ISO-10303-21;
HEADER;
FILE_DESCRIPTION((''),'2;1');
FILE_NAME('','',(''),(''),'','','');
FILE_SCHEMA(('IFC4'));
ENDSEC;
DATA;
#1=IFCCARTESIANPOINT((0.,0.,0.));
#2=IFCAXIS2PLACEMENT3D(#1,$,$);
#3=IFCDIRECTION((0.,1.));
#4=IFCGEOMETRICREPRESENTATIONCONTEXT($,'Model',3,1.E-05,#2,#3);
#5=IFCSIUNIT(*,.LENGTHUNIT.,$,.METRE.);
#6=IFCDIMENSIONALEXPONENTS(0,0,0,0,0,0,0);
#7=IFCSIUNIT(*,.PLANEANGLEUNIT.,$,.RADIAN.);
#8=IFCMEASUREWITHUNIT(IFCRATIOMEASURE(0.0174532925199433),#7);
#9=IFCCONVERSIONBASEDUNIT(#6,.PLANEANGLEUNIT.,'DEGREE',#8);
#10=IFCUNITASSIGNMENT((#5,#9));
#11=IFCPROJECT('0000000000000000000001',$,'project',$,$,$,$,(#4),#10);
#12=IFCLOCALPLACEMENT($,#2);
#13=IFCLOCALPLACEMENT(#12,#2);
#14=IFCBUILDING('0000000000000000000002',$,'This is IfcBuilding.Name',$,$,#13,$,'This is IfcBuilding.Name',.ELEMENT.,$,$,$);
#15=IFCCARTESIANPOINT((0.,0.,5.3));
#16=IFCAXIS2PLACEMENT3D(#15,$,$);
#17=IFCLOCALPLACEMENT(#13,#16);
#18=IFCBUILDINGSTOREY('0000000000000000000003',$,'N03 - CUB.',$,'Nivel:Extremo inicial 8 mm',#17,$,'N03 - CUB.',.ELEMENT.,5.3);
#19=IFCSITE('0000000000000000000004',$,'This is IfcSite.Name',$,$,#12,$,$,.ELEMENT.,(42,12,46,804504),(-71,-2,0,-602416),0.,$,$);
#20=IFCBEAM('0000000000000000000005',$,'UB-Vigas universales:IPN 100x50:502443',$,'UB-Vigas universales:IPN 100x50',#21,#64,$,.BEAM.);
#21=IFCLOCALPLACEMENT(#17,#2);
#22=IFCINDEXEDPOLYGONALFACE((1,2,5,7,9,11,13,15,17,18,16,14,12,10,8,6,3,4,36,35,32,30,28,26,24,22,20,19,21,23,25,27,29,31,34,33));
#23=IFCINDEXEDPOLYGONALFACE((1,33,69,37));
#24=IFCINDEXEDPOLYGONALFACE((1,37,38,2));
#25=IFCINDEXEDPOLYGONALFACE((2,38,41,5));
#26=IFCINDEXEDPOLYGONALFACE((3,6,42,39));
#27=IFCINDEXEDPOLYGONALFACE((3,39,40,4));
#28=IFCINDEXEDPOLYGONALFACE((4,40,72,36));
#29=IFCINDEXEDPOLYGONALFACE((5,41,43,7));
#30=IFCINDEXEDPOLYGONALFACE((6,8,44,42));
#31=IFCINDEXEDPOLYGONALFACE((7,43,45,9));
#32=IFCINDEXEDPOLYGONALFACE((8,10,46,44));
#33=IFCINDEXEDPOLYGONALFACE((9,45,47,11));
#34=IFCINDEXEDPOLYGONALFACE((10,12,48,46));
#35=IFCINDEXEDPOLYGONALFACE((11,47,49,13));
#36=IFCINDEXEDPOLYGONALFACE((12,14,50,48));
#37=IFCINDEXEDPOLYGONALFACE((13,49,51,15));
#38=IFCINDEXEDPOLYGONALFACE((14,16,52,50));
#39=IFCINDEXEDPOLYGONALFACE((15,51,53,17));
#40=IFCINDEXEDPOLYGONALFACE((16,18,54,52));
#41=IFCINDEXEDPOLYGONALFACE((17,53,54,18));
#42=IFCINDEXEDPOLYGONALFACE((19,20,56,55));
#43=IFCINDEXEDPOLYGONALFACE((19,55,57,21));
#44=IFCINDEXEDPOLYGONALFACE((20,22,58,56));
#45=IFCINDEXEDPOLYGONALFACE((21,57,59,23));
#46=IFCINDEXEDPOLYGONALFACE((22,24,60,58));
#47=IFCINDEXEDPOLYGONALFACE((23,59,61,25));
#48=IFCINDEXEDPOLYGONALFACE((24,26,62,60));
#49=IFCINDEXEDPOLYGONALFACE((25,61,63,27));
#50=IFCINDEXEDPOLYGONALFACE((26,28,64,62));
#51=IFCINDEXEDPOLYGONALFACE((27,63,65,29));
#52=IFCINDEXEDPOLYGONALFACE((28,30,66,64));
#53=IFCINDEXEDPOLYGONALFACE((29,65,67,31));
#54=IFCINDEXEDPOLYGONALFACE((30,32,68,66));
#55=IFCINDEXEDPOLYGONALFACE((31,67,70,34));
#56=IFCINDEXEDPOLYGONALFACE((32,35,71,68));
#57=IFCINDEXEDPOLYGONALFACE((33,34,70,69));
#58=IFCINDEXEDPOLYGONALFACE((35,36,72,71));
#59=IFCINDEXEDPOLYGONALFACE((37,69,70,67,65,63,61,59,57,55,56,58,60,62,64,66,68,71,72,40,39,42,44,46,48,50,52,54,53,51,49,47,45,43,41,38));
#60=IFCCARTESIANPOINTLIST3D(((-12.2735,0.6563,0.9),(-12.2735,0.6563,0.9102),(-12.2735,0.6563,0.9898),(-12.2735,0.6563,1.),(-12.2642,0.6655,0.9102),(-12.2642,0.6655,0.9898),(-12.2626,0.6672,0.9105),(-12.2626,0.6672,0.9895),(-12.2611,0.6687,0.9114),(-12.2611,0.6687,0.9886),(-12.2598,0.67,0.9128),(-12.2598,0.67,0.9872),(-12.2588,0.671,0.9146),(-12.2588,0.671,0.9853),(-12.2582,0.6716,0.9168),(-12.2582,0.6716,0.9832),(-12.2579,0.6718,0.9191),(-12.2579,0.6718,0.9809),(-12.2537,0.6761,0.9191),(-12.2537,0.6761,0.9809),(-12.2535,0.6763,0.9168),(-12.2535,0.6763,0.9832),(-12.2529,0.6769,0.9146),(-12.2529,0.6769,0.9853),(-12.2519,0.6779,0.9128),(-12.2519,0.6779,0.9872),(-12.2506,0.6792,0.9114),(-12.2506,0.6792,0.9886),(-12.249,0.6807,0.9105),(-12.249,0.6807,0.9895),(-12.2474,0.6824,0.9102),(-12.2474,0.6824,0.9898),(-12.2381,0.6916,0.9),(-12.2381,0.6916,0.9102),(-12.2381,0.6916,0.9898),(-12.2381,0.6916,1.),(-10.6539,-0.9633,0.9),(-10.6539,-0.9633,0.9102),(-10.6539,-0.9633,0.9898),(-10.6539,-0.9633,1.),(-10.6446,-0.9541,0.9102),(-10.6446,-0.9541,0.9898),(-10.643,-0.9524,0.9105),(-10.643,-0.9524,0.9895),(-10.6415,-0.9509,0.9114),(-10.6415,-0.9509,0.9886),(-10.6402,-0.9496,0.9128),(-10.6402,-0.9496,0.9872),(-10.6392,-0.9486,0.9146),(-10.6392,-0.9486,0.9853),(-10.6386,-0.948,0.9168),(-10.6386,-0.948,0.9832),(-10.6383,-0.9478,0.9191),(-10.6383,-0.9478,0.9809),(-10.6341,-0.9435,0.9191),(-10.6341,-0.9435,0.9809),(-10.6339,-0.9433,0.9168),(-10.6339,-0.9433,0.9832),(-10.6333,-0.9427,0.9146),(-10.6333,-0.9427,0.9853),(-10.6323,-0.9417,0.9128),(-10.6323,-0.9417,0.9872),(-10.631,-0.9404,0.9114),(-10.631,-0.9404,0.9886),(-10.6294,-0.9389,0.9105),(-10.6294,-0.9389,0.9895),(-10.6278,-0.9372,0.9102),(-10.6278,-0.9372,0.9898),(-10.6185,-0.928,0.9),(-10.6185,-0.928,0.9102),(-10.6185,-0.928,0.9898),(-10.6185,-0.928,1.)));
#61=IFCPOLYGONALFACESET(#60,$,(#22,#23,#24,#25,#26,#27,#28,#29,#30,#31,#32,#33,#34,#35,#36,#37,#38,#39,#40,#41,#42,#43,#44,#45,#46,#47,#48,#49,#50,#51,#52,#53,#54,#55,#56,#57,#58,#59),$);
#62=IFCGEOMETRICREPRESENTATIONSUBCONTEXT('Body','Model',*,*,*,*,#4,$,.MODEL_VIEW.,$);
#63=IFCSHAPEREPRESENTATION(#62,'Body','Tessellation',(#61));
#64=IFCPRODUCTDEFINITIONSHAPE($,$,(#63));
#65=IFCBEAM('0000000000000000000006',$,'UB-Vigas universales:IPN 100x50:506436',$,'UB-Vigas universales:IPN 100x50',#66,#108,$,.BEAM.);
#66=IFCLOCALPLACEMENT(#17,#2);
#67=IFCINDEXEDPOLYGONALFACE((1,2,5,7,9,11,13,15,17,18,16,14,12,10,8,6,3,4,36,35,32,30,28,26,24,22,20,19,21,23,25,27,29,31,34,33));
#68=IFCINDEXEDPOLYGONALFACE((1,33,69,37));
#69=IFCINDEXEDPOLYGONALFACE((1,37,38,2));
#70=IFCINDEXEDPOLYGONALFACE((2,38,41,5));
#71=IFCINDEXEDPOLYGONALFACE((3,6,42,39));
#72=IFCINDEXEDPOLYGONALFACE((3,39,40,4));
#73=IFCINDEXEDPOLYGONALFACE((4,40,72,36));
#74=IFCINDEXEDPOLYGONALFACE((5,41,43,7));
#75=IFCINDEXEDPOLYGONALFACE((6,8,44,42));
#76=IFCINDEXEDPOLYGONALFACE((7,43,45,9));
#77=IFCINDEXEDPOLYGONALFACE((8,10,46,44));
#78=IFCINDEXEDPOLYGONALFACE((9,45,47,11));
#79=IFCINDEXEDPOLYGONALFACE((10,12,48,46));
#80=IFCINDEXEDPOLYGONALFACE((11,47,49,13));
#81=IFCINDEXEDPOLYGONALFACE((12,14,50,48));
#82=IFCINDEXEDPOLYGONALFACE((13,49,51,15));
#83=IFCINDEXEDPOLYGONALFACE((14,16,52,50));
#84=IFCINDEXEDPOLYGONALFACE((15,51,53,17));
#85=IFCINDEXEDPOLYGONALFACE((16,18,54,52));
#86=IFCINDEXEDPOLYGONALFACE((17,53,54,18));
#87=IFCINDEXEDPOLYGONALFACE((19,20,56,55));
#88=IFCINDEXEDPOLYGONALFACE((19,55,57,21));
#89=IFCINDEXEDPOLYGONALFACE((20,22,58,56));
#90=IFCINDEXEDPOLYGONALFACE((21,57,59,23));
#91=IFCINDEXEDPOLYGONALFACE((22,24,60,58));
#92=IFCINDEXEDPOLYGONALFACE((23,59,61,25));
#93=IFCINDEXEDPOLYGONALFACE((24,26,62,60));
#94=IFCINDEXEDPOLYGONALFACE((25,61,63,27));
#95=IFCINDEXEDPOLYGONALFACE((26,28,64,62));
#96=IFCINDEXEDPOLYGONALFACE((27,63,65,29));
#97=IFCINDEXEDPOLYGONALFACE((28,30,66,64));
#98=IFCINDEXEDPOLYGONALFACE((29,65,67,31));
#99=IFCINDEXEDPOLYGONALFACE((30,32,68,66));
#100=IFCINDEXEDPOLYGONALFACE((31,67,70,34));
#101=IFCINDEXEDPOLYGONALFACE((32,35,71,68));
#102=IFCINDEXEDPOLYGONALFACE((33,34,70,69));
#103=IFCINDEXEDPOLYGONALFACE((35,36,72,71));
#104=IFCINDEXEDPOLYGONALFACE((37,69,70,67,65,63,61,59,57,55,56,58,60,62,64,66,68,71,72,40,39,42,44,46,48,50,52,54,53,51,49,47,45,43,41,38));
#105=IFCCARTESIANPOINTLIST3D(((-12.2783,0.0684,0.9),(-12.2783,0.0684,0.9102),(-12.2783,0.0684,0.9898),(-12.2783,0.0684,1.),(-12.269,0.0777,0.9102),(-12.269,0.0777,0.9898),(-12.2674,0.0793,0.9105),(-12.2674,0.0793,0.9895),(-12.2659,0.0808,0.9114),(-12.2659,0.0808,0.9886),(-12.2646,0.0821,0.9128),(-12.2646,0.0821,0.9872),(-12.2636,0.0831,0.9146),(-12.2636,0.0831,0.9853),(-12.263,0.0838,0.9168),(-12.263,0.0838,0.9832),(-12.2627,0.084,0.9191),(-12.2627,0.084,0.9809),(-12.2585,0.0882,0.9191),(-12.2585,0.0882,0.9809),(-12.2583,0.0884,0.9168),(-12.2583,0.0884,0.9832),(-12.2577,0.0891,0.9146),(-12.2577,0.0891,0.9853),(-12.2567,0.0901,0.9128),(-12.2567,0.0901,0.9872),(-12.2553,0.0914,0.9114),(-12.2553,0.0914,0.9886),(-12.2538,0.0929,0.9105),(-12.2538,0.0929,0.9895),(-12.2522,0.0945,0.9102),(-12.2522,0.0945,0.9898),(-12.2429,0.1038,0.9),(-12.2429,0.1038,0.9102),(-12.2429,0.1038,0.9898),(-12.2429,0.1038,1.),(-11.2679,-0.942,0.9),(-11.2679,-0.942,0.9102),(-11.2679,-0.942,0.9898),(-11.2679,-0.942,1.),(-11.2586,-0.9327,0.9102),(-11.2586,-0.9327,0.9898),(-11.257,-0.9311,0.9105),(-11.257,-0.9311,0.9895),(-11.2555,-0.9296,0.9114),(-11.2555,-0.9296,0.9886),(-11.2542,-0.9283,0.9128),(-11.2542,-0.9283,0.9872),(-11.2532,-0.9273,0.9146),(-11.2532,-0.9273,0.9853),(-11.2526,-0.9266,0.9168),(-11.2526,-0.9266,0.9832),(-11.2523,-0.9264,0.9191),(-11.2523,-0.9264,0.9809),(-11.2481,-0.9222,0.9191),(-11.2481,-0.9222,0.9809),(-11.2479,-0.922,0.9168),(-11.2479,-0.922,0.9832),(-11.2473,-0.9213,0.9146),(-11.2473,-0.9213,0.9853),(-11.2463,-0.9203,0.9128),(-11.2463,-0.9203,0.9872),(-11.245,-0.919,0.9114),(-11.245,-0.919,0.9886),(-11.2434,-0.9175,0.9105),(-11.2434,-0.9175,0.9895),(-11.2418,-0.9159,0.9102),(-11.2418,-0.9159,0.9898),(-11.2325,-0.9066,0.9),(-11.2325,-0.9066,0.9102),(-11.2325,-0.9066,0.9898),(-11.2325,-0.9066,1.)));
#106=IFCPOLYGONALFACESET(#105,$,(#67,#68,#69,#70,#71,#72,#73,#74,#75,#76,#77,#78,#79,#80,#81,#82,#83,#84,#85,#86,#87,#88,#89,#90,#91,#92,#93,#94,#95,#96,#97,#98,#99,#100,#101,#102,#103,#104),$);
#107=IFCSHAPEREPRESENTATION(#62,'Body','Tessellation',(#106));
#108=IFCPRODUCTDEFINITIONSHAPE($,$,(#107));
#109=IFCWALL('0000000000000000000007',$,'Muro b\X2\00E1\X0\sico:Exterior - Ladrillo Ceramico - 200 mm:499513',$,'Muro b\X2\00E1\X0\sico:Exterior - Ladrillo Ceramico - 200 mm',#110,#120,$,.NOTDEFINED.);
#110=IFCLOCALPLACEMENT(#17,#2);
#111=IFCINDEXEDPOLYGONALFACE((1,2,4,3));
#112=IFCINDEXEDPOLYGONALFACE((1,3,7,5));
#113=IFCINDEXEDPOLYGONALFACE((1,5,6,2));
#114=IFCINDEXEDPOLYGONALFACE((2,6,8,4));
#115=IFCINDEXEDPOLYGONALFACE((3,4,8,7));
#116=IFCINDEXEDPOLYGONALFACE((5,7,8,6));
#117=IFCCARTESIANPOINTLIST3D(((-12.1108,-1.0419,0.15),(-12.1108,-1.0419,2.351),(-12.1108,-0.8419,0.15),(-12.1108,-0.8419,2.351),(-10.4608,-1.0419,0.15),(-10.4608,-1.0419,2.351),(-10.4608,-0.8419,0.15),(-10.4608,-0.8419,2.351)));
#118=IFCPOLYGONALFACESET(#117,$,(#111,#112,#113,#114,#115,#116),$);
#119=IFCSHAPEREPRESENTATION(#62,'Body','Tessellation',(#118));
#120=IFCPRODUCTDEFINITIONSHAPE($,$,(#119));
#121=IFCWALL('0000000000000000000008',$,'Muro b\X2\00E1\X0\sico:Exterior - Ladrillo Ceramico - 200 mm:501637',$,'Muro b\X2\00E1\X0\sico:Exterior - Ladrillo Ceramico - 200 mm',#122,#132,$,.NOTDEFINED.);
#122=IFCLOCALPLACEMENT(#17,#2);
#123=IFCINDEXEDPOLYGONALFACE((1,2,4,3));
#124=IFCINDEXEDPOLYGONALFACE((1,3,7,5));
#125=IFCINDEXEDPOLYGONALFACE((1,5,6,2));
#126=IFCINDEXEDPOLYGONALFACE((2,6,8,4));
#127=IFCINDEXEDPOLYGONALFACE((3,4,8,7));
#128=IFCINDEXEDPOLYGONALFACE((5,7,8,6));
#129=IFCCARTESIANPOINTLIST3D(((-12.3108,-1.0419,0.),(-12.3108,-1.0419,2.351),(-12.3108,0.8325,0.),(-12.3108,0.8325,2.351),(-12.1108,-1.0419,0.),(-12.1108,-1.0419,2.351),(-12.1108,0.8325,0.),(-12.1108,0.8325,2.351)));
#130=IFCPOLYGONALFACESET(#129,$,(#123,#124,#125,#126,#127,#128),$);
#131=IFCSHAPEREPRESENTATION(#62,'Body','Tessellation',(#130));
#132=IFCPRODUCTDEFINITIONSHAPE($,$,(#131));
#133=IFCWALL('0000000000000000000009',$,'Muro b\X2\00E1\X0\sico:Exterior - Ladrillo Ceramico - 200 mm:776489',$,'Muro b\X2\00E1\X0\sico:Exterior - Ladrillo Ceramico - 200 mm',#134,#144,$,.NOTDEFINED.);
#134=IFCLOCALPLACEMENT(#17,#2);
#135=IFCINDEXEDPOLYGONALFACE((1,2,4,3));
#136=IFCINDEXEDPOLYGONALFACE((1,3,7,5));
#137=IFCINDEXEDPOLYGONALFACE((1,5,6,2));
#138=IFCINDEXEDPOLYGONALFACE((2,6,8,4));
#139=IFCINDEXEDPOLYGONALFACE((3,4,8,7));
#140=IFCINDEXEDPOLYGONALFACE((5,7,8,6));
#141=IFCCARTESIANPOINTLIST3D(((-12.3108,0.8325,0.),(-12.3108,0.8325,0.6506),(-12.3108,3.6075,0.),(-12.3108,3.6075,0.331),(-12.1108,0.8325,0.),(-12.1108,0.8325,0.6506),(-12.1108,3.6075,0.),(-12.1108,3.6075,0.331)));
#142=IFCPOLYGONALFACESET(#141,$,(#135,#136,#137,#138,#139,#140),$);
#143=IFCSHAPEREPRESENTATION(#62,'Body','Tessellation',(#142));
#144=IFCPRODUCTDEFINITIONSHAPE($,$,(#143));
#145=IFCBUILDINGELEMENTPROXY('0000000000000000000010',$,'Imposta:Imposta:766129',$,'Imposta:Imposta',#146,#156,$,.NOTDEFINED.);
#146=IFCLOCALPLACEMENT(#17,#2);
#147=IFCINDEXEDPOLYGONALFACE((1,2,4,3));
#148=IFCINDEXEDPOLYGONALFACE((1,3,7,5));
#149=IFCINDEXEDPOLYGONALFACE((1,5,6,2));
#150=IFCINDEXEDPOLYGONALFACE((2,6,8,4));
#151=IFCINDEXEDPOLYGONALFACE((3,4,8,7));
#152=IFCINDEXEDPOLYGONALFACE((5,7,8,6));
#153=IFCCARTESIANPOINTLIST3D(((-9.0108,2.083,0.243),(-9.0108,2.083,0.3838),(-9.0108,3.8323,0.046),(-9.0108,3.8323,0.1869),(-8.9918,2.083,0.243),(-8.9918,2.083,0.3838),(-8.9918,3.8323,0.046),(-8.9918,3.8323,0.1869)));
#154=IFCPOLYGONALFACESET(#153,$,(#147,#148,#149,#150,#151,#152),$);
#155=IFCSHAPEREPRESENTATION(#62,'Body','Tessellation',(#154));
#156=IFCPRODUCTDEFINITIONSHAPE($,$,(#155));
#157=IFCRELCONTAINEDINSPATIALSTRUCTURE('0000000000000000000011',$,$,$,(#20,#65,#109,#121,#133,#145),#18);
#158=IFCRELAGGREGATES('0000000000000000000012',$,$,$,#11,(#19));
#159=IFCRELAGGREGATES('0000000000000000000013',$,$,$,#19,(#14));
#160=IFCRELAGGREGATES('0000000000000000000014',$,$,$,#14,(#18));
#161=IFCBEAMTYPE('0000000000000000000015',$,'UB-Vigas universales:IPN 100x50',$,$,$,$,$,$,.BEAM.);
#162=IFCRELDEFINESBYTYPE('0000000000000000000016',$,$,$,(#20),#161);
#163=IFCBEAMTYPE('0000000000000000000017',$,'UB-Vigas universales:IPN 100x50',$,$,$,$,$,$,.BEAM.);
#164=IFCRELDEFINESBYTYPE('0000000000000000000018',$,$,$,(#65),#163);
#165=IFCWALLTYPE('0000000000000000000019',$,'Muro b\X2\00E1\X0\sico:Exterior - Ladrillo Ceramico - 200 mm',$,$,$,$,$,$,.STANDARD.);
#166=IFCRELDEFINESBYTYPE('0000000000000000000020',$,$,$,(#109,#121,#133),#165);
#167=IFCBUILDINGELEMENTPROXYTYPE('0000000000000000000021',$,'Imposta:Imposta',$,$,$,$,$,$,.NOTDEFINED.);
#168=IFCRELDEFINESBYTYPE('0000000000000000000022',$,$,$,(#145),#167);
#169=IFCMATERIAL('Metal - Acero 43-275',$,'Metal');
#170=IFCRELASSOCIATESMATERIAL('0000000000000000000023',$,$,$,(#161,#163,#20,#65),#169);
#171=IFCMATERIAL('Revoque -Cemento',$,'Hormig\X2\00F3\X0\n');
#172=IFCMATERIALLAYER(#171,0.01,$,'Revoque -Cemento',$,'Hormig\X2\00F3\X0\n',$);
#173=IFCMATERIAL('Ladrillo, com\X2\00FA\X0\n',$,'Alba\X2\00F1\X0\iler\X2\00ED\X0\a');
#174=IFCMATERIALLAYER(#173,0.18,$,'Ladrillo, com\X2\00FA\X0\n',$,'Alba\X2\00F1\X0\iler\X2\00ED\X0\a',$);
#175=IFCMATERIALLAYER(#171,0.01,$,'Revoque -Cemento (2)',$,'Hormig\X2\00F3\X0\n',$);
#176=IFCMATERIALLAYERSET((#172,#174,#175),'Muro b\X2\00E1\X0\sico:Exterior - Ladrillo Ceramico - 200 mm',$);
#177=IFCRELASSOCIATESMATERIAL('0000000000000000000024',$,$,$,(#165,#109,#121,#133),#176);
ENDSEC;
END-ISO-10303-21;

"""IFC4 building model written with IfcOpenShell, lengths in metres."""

from ifc_helpers import new_model, entity, si_unit, converted_unit, direction, frame, frame_2d, origin, place, context, subcontext, project, spatial, polyline, rectangle, i_section, outline, extrude, clip, halfspace, source, transform, mapped, material, layer, layer_set, layer_usage, material_profile, profile_set, profile_usage, type_object, type_shapes, element, save


model = new_model("IFC4")

# Units and contexts
model_context = context("Model", 3, precision=1e-05, world=origin(), true_north=direction((0.0, 1.0)))
body_context = subcontext(model_context, "Body", "Model", "MODEL_VIEW")
ifc_project = project(units=[si_unit("LENGTHUNIT", "METRE"), converted_unit("PLANEANGLEUNIT", "DEGREE", entity("IfcRatioMeasure", 0.0174532925199433), si_unit("PLANEANGLEUNIT", "RADIAN"), dimensions=[0, 0, 0, 0, 0, 0, 0])], contexts=[model_context])

# Site, building, storey
site_placement = place(None, origin())
site = spatial("IfcSite", under=ifc_project, at=site_placement, Name="This is IfcSite.Name", CompositionType="ELEMENT", RefLatitude=(42, 12, 46, 804504), RefLongitude=(-71, -2, 0, -602416), RefElevation=0.0)
building_placement = place(site_placement, origin())
building = spatial("IfcBuilding", under=site, at=building_placement, Name="This is IfcBuilding.Name", LongName="This is IfcBuilding.Name", CompositionType="ELEMENT")
storey_placement = place(building_placement, frame((0.0, 0.0, 5.3)))
storey = spatial("IfcBuildingStorey", under=building, at=storey_placement, Name="N03 - CUB.", ObjectType="Nivel:Extremo inicial 8 mm", LongName="N03 - CUB.", CompositionType="ELEMENT", Elevation=5.3)

# Beams
ifc_material_1 = material(Name="Metal - Acero 43-275", Category="Metal")
ifc_material_profile = material_profile(ifc_material_1, i_section(OverallWidth=0.05, OverallDepth=0.1, WebThickness=0.006, FlangeThickness=0.0102, FilletRadius=0.0089, at=frame_2d((0.0, 0.0), x_axis=(0.0, 1.0))), Name="IPN 100x50")
ifc_profile_set = profile_set([ifc_material_profile], Name="IPN 100x50")
ifc_profile_usage_1 = profile_usage(ifc_profile_set, cardinal=8)
beam_type_1 = type_object("IfcBeamType", Name="UB-Vigas universales:IPN 100x50", PredefinedType="BEAM", material=ifc_profile_set)
shared_shape_1 = source(origin(), body_context, "Body", "SweptSolid", [
    extrude(i_section(OverallWidth=0.05, OverallDepth=0.1, WebThickness=0.006, FlangeThickness=0.0102, FilletRadius=0.0089, at=frame_2d((0.0, 0.0), x_axis=(0.0, 1.0))), frame((-1.1226, 0.0, 0.0), z_axis=(1.0, 0.0, 0.0), x_axis=(0.0, 0.0, -1.0)), (0.0, 0.0, 1.0), 2.2905),
])
type_shapes(beam_type_1, [shared_shape_1])
beam_1_placement = place(storey_placement, frame((-11.43, -0.1518, 0.95), z_axis=(0.0, 0.0, 1.0), x_axis=(-0.707107, 0.707107, 0.0)))
element("IfcBeam", 1, at=beam_1_placement, inside=storey, type_object=beam_type_1, material=ifc_profile_usage_1, Name="UB-Vigas universales:IPN 100x50:502443", ObjectType="UB-Vigas universales:IPN 100x50", PredefinedType="BEAM", context=body_context, shape_type="MappedRepresentation", body=[
    mapped(shared_shape_1, transform((0.0, 0.0, 0.0), scale=1.0)),
])
ifc_profile_usage_2 = profile_usage(ifc_profile_set, cardinal=8)
beam_type_2 = type_object("IfcBeamType", Name="UB-Vigas universales:IPN 100x50", PredefinedType="BEAM", material=ifc_profile_set)
shared_shape_2 = source(origin(), body_context, "Body", "SweptSolid", [
    extrude(i_section(OverallWidth=0.05, OverallDepth=0.1, WebThickness=0.006, FlangeThickness=0.0102, FilletRadius=0.0089, at=frame_2d((0.0, 0.0), x_axis=(0.0, 1.0))), frame((-0.6611, 0.0, 0.0), z_axis=(1.0, 0.0, 0.0), x_axis=(0.0, 0.0, -1.0)), (0.0, 0.0, 1.0), 1.4289),
])
type_shapes(beam_type_2, [shared_shape_2])
beam_2_placement = place(storey_placement, frame((-11.7177, -0.4568, 0.95), z_axis=(0.0, 0.0, 1.0), x_axis=(-0.707107, 0.707107, 0.0)))
element("IfcBeam", 2, at=beam_2_placement, inside=storey, type_object=beam_type_2, material=ifc_profile_usage_2, Name="UB-Vigas universales:IPN 100x50:506436", ObjectType="UB-Vigas universales:IPN 100x50", PredefinedType="BEAM", context=body_context, shape_type="MappedRepresentation", body=[
    mapped(shared_shape_2, transform((0.0, 0.0, 0.0), scale=1.0)),
])

# Walls
ifc_material_2 = material(Name="Revoque -Cemento", Category="Hormigón")
ifc_layer_1 = layer(ifc_material_2, 0.01, Name="Revoque -Cemento", Category="Hormigón")
ifc_material_3 = material(Name="Ladrillo, común", Category="Albañilería")
ifc_layer_2 = layer(ifc_material_3, 0.18, Name="Ladrillo, común", Category="Albañilería")
ifc_layer_3 = layer(ifc_material_2, 0.01, Name="Revoque -Cemento (2)", Category="Hormigón")
ifc_layer_set_1 = layer_set([ifc_layer_1, ifc_layer_2, ifc_layer_3], Name="Muro básico:Exterior - Ladrillo Ceramico - 200 mm")
ifc_layer_usage_1 = layer_usage(ifc_layer_set_1, "AXIS2", "NEGATIVE", 0.1)
wall_type = type_object("IfcWallType", Name="Muro básico:Exterior - Ladrillo Ceramico - 200 mm", PredefinedType="STANDARD", material=ifc_layer_set_1)
wall_1_placement = place(storey_placement, frame((-10.4608, -0.9419, 0.15), z_axis=(0.0, 0.0, 1.0), x_axis=(-1.0, 0.0, 0.0)))
element("IfcWall", 3, at=wall_1_placement, inside=storey, type_object=wall_type, material=ifc_layer_usage_1, Name="Muro básico:Exterior - Ladrillo Ceramico - 200 mm:499513", ObjectType="Muro básico:Exterior - Ladrillo Ceramico - 200 mm", PredefinedType="NOTDEFINED", context=body_context, shape_type="SweptSolid", body=[
    extrude(rectangle(XDim=1.65, YDim=0.2, at=frame_2d((0.825, 0.0), x_axis=(-1.0, 0.0))), origin(), (0.0, 0.0, 1.0), 2.201),
])
ifc_layer_usage_2 = layer_usage(ifc_layer_set_1, "AXIS2", "POSITIVE", -0.1)
wall_2_placement = place(storey_placement, frame((-12.2108, 0.8325, 0.0), z_axis=(0.0, 0.0, 1.0), x_axis=(0.0, -1.0, 0.0)))
element("IfcWall", 4, at=wall_2_placement, inside=storey, type_object=wall_type, material=ifc_layer_usage_2, Name="Muro básico:Exterior - Ladrillo Ceramico - 200 mm:501637", ObjectType="Muro básico:Exterior - Ladrillo Ceramico - 200 mm", PredefinedType="NOTDEFINED", context=body_context, shape_type="SweptSolid", body=[
    extrude(rectangle(XDim=1.8744, YDim=0.2, at=frame_2d((0.9372, 0.0), x_axis=(-1.0, 0.0))), origin(), (0.0, 0.0, 1.0), 2.351),
])
ifc_layer_usage_3 = layer_usage(ifc_layer_set_1, "AXIS2", "POSITIVE", -0.1)
wall_3_placement = place(storey_placement, frame((-12.2108, 3.6075, 0.0), z_axis=(0.0, 0.0, 1.0), x_axis=(0.0, -1.0, 0.0)))
element("IfcWall", 5, at=wall_3_placement, inside=storey, type_object=wall_type, material=ifc_layer_usage_3, Name="Muro básico:Exterior - Ladrillo Ceramico - 200 mm:776489", ObjectType="Muro básico:Exterior - Ladrillo Ceramico - 200 mm", PredefinedType="NOTDEFINED", context=body_context, shape_type="Clipping", body=[
    clip(extrude(rectangle(XDim=2.775, YDim=0.2, at=frame_2d((1.3875, 0.0), x_axis=(-1.0, 0.0))), origin(), (0.0, 0.0, 1.0), 0.6506), halfspace(frame((0.0, -0.1, 0.331), z_axis=(-0.114424, 0.0, 0.993432), x_axis=(0.0, 1.0, 0.0)), False)),
])

# Building element proxy
building_element_proxy_type = type_object("IfcBuildingElementProxyType", Name="Imposta:Imposta", PredefinedType="NOTDEFINED")
proxy_placement = place(storey_placement, frame((-9.0108, 2.083, 0.046)))
element("IfcBuildingElementProxy", 6, at=proxy_placement, inside=storey, type_object=building_element_proxy_type, Name="Imposta:Imposta:766129", ObjectType="Imposta:Imposta", PredefinedType="NOTDEFINED", context=body_context, shape_type="SweptSolid", body=[
    extrude(outline(polyline([(-0.8723, -0.07), (0.888, -0.07), (0.8723, 0.07), (-0.888, 0.07), (-0.8723, -0.07)])), frame((0.0, 0.8746, 0.1689), z_axis=(1.0, 0.0, 0.0), x_axis=(0.0, 0.993721, -0.111886)), (0.0, 0.0, 1.0), 0.019),
])

save(model, "model.ifc")
